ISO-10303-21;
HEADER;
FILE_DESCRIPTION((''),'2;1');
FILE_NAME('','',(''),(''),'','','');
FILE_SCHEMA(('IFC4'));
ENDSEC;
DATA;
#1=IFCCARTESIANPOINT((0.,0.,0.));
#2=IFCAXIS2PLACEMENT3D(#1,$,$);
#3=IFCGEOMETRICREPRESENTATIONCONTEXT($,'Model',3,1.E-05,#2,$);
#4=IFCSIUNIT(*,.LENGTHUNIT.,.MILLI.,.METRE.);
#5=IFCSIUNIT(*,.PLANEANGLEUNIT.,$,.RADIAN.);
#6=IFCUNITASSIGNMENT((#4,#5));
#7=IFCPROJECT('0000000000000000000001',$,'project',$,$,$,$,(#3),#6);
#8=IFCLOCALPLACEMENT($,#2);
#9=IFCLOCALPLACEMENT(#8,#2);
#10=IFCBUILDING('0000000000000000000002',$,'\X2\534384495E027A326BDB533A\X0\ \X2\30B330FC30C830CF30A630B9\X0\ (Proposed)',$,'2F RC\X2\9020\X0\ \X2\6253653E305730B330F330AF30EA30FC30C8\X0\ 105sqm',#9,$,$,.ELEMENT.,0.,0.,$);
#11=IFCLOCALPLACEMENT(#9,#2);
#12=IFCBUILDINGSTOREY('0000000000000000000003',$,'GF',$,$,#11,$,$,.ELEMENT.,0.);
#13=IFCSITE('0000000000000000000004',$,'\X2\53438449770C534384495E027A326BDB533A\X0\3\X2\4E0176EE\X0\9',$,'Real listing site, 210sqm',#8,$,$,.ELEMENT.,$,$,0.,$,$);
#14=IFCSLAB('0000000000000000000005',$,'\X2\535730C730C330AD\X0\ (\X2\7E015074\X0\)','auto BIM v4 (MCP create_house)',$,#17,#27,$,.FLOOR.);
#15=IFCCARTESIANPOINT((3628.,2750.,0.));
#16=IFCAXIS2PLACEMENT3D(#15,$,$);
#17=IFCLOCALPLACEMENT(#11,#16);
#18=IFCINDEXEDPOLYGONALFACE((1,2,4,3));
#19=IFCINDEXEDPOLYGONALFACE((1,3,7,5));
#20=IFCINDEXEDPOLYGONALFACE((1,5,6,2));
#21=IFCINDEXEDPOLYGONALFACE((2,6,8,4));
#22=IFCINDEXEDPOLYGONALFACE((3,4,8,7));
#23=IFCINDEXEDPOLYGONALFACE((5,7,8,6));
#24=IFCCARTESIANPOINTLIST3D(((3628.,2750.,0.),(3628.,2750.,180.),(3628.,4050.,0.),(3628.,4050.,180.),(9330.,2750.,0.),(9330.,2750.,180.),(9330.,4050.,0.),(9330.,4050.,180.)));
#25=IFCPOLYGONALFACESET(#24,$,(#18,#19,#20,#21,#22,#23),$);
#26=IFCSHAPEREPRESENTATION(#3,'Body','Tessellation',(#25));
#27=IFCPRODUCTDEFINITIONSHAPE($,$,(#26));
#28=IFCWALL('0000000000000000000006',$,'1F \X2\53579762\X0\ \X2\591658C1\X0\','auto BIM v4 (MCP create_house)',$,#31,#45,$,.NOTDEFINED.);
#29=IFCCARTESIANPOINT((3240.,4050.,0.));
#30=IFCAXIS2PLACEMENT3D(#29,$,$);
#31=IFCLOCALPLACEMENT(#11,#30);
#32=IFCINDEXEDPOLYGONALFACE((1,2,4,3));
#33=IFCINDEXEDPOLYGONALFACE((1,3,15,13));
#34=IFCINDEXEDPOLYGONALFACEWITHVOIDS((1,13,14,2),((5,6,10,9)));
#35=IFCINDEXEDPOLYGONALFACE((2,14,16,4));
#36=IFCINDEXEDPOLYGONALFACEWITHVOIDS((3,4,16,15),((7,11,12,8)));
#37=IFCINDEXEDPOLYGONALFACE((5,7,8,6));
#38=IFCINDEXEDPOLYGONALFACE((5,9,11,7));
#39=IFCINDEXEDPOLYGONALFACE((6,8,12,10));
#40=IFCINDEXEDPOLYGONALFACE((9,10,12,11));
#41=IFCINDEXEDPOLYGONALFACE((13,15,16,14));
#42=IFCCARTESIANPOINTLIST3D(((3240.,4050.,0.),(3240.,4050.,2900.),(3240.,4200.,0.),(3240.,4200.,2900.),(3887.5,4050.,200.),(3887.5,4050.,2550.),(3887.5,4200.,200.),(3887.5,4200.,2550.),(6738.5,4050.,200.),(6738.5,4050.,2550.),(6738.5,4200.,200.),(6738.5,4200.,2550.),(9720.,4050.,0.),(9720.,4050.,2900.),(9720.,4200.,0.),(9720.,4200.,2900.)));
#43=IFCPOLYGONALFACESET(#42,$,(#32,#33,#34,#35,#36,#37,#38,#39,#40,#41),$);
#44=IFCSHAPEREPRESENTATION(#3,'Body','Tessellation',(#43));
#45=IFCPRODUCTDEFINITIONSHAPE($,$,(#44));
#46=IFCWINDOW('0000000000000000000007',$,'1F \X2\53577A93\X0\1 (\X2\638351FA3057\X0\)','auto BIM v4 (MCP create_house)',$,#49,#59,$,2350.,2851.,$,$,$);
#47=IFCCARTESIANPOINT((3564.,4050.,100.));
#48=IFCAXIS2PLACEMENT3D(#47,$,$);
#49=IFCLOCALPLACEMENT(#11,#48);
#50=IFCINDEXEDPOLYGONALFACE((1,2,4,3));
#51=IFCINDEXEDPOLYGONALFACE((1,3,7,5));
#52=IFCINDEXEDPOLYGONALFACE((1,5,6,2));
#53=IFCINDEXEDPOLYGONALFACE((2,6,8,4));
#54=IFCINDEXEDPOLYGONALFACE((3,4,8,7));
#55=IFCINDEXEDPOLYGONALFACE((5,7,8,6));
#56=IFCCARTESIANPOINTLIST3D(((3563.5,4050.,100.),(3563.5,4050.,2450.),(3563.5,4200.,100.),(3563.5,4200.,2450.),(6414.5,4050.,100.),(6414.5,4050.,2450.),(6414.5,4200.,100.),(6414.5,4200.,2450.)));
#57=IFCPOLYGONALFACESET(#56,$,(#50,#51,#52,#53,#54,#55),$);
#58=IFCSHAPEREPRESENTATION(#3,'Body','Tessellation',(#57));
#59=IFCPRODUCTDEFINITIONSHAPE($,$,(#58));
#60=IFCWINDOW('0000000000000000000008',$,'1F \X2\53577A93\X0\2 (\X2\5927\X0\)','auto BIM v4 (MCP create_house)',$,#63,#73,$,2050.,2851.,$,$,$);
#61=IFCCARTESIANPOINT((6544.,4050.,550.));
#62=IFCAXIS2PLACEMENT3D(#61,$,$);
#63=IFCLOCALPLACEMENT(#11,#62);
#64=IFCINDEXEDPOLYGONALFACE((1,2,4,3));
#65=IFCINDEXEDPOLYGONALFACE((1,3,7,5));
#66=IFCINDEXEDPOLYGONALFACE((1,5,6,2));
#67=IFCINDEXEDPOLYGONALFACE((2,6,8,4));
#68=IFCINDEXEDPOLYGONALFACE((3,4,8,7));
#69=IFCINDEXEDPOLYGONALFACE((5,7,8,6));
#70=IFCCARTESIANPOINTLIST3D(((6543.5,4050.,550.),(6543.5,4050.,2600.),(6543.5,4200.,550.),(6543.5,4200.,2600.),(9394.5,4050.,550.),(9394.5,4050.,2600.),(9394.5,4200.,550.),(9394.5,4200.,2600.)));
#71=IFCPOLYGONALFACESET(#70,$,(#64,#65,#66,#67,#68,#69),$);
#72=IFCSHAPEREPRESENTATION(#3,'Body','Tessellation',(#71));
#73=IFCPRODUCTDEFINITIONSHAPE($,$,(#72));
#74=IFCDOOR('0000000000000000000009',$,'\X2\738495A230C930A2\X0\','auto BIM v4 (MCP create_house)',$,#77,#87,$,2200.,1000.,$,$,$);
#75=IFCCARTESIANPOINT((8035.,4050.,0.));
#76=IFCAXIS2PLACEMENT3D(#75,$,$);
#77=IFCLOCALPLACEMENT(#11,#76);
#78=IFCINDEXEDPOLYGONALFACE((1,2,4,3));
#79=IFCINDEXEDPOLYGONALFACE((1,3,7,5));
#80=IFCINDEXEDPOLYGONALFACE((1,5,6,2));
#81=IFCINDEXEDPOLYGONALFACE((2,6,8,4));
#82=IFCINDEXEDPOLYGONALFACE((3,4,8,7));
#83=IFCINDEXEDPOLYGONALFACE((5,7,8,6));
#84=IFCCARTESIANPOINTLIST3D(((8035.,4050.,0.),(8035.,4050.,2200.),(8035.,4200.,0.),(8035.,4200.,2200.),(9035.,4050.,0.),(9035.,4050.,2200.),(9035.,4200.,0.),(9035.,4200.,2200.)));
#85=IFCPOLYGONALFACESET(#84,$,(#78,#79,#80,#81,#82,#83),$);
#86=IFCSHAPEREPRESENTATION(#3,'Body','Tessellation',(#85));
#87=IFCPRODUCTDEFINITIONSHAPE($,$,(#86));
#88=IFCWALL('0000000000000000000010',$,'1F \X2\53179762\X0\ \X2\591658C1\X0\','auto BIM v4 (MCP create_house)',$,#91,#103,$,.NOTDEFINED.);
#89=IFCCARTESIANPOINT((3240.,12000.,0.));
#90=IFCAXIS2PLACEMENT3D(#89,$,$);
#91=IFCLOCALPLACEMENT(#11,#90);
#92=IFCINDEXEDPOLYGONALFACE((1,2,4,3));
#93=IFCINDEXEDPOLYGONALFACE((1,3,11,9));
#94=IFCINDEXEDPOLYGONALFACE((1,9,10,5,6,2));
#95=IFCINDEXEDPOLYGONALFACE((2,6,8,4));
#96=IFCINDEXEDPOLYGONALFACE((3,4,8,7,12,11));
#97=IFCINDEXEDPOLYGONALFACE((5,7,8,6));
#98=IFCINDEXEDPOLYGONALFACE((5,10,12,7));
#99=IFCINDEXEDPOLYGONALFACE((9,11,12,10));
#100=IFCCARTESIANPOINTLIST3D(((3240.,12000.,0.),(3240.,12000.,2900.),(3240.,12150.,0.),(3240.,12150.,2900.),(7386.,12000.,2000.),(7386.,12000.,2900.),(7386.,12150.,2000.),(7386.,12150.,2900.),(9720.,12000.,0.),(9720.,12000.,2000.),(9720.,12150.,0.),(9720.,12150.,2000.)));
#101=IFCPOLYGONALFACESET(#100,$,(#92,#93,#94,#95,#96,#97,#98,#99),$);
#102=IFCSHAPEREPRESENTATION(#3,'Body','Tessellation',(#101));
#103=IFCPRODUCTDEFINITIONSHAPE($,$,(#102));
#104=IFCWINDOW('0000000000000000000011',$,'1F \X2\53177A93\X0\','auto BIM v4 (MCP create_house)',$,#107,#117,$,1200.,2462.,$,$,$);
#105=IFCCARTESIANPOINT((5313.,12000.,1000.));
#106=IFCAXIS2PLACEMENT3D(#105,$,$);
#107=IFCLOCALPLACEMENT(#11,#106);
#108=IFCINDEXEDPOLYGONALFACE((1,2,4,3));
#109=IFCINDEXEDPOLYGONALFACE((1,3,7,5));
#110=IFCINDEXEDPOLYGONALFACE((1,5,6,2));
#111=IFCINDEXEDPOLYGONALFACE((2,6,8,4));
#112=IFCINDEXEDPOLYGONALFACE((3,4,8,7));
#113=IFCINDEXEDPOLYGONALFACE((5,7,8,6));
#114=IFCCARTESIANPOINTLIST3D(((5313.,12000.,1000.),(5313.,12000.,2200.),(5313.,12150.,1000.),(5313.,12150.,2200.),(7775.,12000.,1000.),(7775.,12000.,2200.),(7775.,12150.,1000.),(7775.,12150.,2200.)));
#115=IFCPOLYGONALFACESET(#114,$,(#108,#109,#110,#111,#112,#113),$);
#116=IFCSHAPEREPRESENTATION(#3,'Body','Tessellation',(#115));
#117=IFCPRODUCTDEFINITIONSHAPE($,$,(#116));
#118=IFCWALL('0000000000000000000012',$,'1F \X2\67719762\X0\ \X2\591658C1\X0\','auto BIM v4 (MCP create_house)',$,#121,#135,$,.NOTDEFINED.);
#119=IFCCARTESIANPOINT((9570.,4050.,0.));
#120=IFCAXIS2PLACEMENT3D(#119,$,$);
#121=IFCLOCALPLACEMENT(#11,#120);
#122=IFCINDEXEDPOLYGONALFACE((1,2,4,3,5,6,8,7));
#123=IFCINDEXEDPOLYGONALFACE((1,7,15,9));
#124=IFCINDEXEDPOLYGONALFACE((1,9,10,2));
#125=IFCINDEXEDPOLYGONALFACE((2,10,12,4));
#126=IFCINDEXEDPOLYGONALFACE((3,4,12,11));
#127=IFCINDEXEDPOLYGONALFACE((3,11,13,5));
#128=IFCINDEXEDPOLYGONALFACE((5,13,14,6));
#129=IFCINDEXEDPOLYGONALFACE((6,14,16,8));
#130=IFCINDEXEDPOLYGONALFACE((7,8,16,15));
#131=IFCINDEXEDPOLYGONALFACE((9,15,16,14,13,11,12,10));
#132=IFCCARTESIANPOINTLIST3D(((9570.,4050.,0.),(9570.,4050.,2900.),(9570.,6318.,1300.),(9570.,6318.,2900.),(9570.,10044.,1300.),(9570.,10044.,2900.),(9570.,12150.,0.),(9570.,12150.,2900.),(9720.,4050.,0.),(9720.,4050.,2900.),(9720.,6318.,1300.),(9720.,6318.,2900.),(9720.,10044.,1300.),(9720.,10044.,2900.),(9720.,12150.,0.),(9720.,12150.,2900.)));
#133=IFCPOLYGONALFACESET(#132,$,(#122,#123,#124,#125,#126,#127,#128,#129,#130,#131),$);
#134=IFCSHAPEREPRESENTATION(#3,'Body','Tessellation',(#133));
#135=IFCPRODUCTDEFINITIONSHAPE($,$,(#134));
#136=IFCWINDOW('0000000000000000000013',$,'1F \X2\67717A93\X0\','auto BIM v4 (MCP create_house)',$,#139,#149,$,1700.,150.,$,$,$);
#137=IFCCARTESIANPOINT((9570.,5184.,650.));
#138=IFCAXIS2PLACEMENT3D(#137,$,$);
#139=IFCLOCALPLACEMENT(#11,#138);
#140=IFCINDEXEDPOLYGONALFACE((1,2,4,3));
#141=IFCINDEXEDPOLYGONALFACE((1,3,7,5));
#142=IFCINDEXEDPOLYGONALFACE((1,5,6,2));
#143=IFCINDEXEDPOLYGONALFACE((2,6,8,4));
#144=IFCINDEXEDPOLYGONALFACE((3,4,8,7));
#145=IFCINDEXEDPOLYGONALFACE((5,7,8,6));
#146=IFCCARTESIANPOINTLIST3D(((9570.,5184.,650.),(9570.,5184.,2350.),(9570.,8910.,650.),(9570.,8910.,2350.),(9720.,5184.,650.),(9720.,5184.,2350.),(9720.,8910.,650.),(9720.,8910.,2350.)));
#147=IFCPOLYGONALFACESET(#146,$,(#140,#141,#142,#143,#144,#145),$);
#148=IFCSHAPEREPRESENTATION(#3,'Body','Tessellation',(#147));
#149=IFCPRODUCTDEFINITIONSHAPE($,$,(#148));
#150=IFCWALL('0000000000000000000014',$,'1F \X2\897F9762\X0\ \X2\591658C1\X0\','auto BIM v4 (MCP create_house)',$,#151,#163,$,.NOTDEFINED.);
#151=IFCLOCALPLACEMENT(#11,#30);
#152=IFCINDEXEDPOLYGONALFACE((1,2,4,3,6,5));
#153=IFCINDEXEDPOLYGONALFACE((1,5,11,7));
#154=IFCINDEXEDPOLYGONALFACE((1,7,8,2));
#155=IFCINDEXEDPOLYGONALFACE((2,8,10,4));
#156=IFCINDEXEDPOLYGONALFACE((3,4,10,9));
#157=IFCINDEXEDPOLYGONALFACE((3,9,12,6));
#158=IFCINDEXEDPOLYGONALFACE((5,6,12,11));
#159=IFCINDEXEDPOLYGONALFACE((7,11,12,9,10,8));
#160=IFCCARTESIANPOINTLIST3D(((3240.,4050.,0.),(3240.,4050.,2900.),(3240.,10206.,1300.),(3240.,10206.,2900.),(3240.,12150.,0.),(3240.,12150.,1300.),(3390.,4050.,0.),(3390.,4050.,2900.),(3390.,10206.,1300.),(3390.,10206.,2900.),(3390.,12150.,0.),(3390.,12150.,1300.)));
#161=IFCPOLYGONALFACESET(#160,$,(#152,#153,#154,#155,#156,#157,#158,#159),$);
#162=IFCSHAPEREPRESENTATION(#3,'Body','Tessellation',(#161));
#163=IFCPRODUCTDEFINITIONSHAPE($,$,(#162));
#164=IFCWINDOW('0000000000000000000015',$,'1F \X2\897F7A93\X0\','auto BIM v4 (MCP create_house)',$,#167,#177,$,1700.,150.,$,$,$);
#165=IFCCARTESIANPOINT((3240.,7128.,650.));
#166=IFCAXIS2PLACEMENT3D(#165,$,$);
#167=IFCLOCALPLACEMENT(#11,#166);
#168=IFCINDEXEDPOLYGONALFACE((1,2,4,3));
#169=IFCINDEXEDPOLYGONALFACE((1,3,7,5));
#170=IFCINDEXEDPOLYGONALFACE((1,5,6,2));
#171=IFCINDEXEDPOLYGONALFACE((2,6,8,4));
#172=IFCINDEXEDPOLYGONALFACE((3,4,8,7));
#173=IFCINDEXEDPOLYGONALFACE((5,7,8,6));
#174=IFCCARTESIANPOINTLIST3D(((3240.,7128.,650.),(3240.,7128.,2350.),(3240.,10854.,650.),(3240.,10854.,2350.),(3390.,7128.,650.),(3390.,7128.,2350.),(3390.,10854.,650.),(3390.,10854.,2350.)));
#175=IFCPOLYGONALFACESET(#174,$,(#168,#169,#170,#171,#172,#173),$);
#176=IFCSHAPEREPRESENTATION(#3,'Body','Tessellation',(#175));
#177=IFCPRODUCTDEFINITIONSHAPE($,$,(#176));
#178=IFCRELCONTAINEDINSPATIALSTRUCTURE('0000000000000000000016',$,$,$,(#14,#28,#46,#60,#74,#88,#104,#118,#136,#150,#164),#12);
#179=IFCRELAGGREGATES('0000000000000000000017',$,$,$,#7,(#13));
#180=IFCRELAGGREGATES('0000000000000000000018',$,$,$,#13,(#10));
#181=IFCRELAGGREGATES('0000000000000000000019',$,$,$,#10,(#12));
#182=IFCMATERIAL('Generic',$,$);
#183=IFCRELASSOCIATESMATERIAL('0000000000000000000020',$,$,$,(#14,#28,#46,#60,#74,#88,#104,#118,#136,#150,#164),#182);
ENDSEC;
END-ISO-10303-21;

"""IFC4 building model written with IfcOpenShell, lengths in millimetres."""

from ifc_helpers import new_model, si_unit, frame, frame_2d, origin, place, context, project, spatial, rectangle, extrude, material, element, fill, save


model = new_model("IFC4")

# Units and contexts
model_context = context("Model", 3, precision=1e-05, world=origin())
ifc_project = project(units=[si_unit("LENGTHUNIT", "METRE", prefix="MILLI"), si_unit("PLANEANGLEUNIT", "RADIAN")], contexts=[model_context])

# Site, building, storey
site_placement = place(None, origin())
site = spatial("IfcSite", under=ifc_project, at=site_placement, Name="千葉県千葉市稲毛区3丁目9", ObjectType="Real listing site, 210sqm", CompositionType="ELEMENT", RefElevation=0.0)
building_placement = place(site_placement, origin())
building = spatial("IfcBuilding", under=site, at=building_placement, Name="千葉市稲毛区 コートハウス (Proposed)", ObjectType="2F RC造 打放しコンクリート 105sqm", CompositionType="ELEMENT", ElevationOfRefHeight=0.0, ElevationOfTerrain=0.0)
storey_placement = place(building_placement, origin())
storey = spatial("IfcBuildingStorey", under=building, at=storey_placement, Name="GF", CompositionType="ELEMENT", Elevation=0.0)

# Slab
ifc_material = material(Name="Generic")
slab_1_placement = place(storey_placement, frame((3628.0, 2750.0, 0.0)))
element("IfcSlab", 1, at=slab_1_placement, inside=storey, material=ifc_material, Name="南デッキ (縁側)", Description="auto BIM v4 (MCP create_house)", PredefinedType="FLOOR", context=model_context, shape_type="SweptSolid", body=[
    extrude(rectangle(XDim=5702.0, YDim=1300.0, at=frame_2d((2851.0, 650.0))), frame((3628.0, 2750.0, 0.0)), (0.0, 0.0, 1.0), 180.0),
])

# Wall, openings, windows, door
wall_1_placement = place(storey_placement, frame((3240.0, 4050.0, 0.0)))
wall_1 = element("IfcWall", 2, at=wall_1_placement, inside=storey, material=ifc_material, Name="1F 南面 外壁", Description="auto BIM v4 (MCP create_house)", PredefinedType="NOTDEFINED", context=model_context, shape_type="SweptSolid", body=[
    extrude(rectangle(XDim=6480.0, YDim=150.0, at=frame_2d((3240.0, 75.0))), frame((3240.0, 4050.0, 0.0)), (0.0, 0.0, 1.0), 2900.0),
])
opening_1_placement = place(storey_placement, frame((3564.0, 4050.0, 100.0)))
opening_1 = element("IfcOpeningElement", 3, at=opening_1_placement, cuts=wall_1, PredefinedType="NOTDEFINED", context=model_context, shape_type="SweptSolid", body=[
    extrude(rectangle(XDim=2851.0, YDim=150.0, at=frame_2d((1425.0, 75.0))), frame((3564.0, 4050.0, 100.0)), (0.0, 0.0, 1.0), 2350.0),
])
opening_2_placement = place(storey_placement, frame((6544.0, 4050.0, 550.0)))
opening_2 = element("IfcOpeningElement", 4, at=opening_2_placement, cuts=wall_1, PredefinedType="NOTDEFINED", context=model_context, shape_type="SweptSolid", body=[
    extrude(rectangle(XDim=2851.0, YDim=150.0, at=frame_2d((1425.0, 75.0))), frame((6544.0, 4050.0, 550.0)), (0.0, 0.0, 1.0), 2050.0),
])
opening_3_placement = place(storey_placement, frame((8035.0, 4050.0, 0.0)))
opening_3 = element("IfcOpeningElement", 5, at=opening_3_placement, cuts=wall_1, PredefinedType="NOTDEFINED", context=model_context, shape_type="SweptSolid", body=[
    extrude(rectangle(XDim=1000.0, YDim=150.0, at=frame_2d((500.0, 75.0))), frame((8035.0, 4050.0, 0.0)), (0.0, 0.0, 1.0), 2200.0),
])
window_1_placement = place(storey_placement, frame((3564.0, 4050.0, 100.0)))
window_1 = element("IfcWindow", 6, at=window_1_placement, inside=storey, material=ifc_material, Name="1F 南窓1 (掃出し)", Description="auto BIM v4 (MCP create_house)", OverallHeight=2350.0, OverallWidth=2851.0, context=model_context, shape_type="SweptSolid", body=[
    extrude(rectangle(XDim=2851.0, YDim=150.0, at=frame_2d((1425.0, 75.0))), frame((3564.0, 4050.0, 100.0)), (0.0, 0.0, 1.0), 2350.0),
])
fill(opening_1, window_1)
window_2_placement = place(storey_placement, frame((6544.0, 4050.0, 550.0)))
window_2 = element("IfcWindow", 7, at=window_2_placement, inside=storey, material=ifc_material, Name="1F 南窓2 (大)", Description="auto BIM v4 (MCP create_house)", OverallHeight=2050.0, OverallWidth=2851.0, context=model_context, shape_type="SweptSolid", body=[
    extrude(rectangle(XDim=2851.0, YDim=150.0, at=frame_2d((1425.0, 75.0))), frame((6544.0, 4050.0, 550.0)), (0.0, 0.0, 1.0), 2050.0),
])
fill(opening_2, window_2)
door_1_placement = place(storey_placement, frame((8035.0, 4050.0, 0.0)))
door_1 = element("IfcDoor", 8, at=door_1_placement, inside=storey, material=ifc_material, Name="玄関ドア", Description="auto BIM v4 (MCP create_house)", OverallHeight=2200.0, OverallWidth=1000.0, context=model_context, shape_type="SweptSolid", body=[
    extrude(rectangle(XDim=1000.0, YDim=150.0, at=frame_2d((500.0, 75.0))), frame((8035.0, 4050.0, 0.0)), (0.0, 0.0, 1.0), 2200.0),
])
fill(opening_3, door_1)

# Walls, openings, windows
wall_2_placement = place(storey_placement, frame((3240.0, 12000.0, 0.0)))
wall_2 = element("IfcWall", 9, at=wall_2_placement, inside=storey, material=ifc_material, Name="1F 北面 外壁", Description="auto BIM v4 (MCP create_house)", PredefinedType="NOTDEFINED", context=model_context, shape_type="SweptSolid", body=[
    extrude(rectangle(XDim=6480.0, YDim=150.0, at=frame_2d((3240.0, 75.0))), frame((3240.0, 12000.0, 0.0)), (0.0, 0.0, 1.0), 2900.0),
])
opening_4_placement = place(storey_placement, frame((5313.0, 12000.0, 1000.0)))
opening_4 = element("IfcOpeningElement", 10, at=opening_4_placement, cuts=wall_2, PredefinedType="NOTDEFINED", context=model_context, shape_type="SweptSolid", body=[
    extrude(rectangle(XDim=2462.0, YDim=150.0, at=frame_2d((1231.0, 75.0))), frame((5313.0, 12000.0, 1000.0)), (0.0, 0.0, 1.0), 1200.0),
])
window_3_placement = place(storey_placement, frame((5313.0, 12000.0, 1000.0)))
window_3 = element("IfcWindow", 11, at=window_3_placement, inside=storey, material=ifc_material, Name="1F 北窓", Description="auto BIM v4 (MCP create_house)", OverallHeight=1200.0, OverallWidth=2462.0, context=model_context, shape_type="SweptSolid", body=[
    extrude(rectangle(XDim=2462.0, YDim=150.0, at=frame_2d((1231.0, 75.0))), frame((5313.0, 12000.0, 1000.0)), (0.0, 0.0, 1.0), 1200.0),
])
fill(opening_4, window_3)
wall_3_placement = place(storey_placement, frame((9570.0, 4050.0, 0.0)))
wall_3 = element("IfcWall", 12, at=wall_3_placement, inside=storey, material=ifc_material, Name="1F 東面 外壁", Description="auto BIM v4 (MCP create_house)", PredefinedType="NOTDEFINED", context=model_context, shape_type="SweptSolid", body=[
    extrude(rectangle(XDim=150.0, YDim=8100.0, at=frame_2d((75.0, 4050.0))), frame((9570.0, 4050.0, 0.0)), (0.0, 0.0, 1.0), 2900.0),
])
opening_5_placement = place(storey_placement, frame((9570.0, 5184.0, 650.0)))
opening_5 = element("IfcOpeningElement", 13, at=opening_5_placement, cuts=wall_3, PredefinedType="NOTDEFINED", context=model_context, shape_type="SweptSolid", body=[
    extrude(rectangle(XDim=150.0, YDim=3726.0, at=frame_2d((75.0, 1863.0))), frame((9570.0, 5184.0, 650.0)), (0.0, 0.0, 1.0), 1700.0),
])
window_4_placement = place(storey_placement, frame((9570.0, 5184.0, 650.0)))
window_4 = element("IfcWindow", 14, at=window_4_placement, inside=storey, material=ifc_material, Name="1F 東窓", Description="auto BIM v4 (MCP create_house)", OverallHeight=1700.0, OverallWidth=150.0, context=model_context, shape_type="SweptSolid", body=[
    extrude(rectangle(XDim=150.0, YDim=3726.0, at=frame_2d((75.0, 1863.0))), frame((9570.0, 5184.0, 650.0)), (0.0, 0.0, 1.0), 1700.0),
])
fill(opening_5, window_4)
wall_4_placement = place(storey_placement, frame((3240.0, 4050.0, 0.0)))
wall_4 = element("IfcWall", 15, at=wall_4_placement, inside=storey, material=ifc_material, Name="1F 西面 外壁", Description="auto BIM v4 (MCP create_house)", PredefinedType="NOTDEFINED", context=model_context, shape_type="SweptSolid", body=[
    extrude(rectangle(XDim=150.0, YDim=8100.0, at=frame_2d((75.0, 4050.0))), frame((3240.0, 4050.0, 0.0)), (0.0, 0.0, 1.0), 2900.0),
])
opening_6_placement = place(storey_placement, frame((3240.0, 7128.0, 650.0)))
opening_6 = element("IfcOpeningElement", 16, at=opening_6_placement, cuts=wall_4, PredefinedType="NOTDEFINED", context=model_context, shape_type="SweptSolid", body=[
    extrude(rectangle(XDim=150.0, YDim=3726.0, at=frame_2d((75.0, 1863.0))), frame((3240.0, 7128.0, 650.0)), (0.0, 0.0, 1.0), 1700.0),
])
window_5_placement = place(storey_placement, frame((3240.0, 7128.0, 650.0)))
window_5 = element("IfcWindow", 17, at=window_5_placement, inside=storey, material=ifc_material, Name="1F 西窓", Description="auto BIM v4 (MCP create_house)", OverallHeight=1700.0, OverallWidth=150.0, context=model_context, shape_type="SweptSolid", body=[
    extrude(rectangle(XDim=150.0, YDim=3726.0, at=frame_2d((75.0, 1863.0))), frame((3240.0, 7128.0, 650.0)), (0.0, 0.0, 1.0), 1700.0),
])
fill(opening_6, window_5)

save(model, "model.ifc")
